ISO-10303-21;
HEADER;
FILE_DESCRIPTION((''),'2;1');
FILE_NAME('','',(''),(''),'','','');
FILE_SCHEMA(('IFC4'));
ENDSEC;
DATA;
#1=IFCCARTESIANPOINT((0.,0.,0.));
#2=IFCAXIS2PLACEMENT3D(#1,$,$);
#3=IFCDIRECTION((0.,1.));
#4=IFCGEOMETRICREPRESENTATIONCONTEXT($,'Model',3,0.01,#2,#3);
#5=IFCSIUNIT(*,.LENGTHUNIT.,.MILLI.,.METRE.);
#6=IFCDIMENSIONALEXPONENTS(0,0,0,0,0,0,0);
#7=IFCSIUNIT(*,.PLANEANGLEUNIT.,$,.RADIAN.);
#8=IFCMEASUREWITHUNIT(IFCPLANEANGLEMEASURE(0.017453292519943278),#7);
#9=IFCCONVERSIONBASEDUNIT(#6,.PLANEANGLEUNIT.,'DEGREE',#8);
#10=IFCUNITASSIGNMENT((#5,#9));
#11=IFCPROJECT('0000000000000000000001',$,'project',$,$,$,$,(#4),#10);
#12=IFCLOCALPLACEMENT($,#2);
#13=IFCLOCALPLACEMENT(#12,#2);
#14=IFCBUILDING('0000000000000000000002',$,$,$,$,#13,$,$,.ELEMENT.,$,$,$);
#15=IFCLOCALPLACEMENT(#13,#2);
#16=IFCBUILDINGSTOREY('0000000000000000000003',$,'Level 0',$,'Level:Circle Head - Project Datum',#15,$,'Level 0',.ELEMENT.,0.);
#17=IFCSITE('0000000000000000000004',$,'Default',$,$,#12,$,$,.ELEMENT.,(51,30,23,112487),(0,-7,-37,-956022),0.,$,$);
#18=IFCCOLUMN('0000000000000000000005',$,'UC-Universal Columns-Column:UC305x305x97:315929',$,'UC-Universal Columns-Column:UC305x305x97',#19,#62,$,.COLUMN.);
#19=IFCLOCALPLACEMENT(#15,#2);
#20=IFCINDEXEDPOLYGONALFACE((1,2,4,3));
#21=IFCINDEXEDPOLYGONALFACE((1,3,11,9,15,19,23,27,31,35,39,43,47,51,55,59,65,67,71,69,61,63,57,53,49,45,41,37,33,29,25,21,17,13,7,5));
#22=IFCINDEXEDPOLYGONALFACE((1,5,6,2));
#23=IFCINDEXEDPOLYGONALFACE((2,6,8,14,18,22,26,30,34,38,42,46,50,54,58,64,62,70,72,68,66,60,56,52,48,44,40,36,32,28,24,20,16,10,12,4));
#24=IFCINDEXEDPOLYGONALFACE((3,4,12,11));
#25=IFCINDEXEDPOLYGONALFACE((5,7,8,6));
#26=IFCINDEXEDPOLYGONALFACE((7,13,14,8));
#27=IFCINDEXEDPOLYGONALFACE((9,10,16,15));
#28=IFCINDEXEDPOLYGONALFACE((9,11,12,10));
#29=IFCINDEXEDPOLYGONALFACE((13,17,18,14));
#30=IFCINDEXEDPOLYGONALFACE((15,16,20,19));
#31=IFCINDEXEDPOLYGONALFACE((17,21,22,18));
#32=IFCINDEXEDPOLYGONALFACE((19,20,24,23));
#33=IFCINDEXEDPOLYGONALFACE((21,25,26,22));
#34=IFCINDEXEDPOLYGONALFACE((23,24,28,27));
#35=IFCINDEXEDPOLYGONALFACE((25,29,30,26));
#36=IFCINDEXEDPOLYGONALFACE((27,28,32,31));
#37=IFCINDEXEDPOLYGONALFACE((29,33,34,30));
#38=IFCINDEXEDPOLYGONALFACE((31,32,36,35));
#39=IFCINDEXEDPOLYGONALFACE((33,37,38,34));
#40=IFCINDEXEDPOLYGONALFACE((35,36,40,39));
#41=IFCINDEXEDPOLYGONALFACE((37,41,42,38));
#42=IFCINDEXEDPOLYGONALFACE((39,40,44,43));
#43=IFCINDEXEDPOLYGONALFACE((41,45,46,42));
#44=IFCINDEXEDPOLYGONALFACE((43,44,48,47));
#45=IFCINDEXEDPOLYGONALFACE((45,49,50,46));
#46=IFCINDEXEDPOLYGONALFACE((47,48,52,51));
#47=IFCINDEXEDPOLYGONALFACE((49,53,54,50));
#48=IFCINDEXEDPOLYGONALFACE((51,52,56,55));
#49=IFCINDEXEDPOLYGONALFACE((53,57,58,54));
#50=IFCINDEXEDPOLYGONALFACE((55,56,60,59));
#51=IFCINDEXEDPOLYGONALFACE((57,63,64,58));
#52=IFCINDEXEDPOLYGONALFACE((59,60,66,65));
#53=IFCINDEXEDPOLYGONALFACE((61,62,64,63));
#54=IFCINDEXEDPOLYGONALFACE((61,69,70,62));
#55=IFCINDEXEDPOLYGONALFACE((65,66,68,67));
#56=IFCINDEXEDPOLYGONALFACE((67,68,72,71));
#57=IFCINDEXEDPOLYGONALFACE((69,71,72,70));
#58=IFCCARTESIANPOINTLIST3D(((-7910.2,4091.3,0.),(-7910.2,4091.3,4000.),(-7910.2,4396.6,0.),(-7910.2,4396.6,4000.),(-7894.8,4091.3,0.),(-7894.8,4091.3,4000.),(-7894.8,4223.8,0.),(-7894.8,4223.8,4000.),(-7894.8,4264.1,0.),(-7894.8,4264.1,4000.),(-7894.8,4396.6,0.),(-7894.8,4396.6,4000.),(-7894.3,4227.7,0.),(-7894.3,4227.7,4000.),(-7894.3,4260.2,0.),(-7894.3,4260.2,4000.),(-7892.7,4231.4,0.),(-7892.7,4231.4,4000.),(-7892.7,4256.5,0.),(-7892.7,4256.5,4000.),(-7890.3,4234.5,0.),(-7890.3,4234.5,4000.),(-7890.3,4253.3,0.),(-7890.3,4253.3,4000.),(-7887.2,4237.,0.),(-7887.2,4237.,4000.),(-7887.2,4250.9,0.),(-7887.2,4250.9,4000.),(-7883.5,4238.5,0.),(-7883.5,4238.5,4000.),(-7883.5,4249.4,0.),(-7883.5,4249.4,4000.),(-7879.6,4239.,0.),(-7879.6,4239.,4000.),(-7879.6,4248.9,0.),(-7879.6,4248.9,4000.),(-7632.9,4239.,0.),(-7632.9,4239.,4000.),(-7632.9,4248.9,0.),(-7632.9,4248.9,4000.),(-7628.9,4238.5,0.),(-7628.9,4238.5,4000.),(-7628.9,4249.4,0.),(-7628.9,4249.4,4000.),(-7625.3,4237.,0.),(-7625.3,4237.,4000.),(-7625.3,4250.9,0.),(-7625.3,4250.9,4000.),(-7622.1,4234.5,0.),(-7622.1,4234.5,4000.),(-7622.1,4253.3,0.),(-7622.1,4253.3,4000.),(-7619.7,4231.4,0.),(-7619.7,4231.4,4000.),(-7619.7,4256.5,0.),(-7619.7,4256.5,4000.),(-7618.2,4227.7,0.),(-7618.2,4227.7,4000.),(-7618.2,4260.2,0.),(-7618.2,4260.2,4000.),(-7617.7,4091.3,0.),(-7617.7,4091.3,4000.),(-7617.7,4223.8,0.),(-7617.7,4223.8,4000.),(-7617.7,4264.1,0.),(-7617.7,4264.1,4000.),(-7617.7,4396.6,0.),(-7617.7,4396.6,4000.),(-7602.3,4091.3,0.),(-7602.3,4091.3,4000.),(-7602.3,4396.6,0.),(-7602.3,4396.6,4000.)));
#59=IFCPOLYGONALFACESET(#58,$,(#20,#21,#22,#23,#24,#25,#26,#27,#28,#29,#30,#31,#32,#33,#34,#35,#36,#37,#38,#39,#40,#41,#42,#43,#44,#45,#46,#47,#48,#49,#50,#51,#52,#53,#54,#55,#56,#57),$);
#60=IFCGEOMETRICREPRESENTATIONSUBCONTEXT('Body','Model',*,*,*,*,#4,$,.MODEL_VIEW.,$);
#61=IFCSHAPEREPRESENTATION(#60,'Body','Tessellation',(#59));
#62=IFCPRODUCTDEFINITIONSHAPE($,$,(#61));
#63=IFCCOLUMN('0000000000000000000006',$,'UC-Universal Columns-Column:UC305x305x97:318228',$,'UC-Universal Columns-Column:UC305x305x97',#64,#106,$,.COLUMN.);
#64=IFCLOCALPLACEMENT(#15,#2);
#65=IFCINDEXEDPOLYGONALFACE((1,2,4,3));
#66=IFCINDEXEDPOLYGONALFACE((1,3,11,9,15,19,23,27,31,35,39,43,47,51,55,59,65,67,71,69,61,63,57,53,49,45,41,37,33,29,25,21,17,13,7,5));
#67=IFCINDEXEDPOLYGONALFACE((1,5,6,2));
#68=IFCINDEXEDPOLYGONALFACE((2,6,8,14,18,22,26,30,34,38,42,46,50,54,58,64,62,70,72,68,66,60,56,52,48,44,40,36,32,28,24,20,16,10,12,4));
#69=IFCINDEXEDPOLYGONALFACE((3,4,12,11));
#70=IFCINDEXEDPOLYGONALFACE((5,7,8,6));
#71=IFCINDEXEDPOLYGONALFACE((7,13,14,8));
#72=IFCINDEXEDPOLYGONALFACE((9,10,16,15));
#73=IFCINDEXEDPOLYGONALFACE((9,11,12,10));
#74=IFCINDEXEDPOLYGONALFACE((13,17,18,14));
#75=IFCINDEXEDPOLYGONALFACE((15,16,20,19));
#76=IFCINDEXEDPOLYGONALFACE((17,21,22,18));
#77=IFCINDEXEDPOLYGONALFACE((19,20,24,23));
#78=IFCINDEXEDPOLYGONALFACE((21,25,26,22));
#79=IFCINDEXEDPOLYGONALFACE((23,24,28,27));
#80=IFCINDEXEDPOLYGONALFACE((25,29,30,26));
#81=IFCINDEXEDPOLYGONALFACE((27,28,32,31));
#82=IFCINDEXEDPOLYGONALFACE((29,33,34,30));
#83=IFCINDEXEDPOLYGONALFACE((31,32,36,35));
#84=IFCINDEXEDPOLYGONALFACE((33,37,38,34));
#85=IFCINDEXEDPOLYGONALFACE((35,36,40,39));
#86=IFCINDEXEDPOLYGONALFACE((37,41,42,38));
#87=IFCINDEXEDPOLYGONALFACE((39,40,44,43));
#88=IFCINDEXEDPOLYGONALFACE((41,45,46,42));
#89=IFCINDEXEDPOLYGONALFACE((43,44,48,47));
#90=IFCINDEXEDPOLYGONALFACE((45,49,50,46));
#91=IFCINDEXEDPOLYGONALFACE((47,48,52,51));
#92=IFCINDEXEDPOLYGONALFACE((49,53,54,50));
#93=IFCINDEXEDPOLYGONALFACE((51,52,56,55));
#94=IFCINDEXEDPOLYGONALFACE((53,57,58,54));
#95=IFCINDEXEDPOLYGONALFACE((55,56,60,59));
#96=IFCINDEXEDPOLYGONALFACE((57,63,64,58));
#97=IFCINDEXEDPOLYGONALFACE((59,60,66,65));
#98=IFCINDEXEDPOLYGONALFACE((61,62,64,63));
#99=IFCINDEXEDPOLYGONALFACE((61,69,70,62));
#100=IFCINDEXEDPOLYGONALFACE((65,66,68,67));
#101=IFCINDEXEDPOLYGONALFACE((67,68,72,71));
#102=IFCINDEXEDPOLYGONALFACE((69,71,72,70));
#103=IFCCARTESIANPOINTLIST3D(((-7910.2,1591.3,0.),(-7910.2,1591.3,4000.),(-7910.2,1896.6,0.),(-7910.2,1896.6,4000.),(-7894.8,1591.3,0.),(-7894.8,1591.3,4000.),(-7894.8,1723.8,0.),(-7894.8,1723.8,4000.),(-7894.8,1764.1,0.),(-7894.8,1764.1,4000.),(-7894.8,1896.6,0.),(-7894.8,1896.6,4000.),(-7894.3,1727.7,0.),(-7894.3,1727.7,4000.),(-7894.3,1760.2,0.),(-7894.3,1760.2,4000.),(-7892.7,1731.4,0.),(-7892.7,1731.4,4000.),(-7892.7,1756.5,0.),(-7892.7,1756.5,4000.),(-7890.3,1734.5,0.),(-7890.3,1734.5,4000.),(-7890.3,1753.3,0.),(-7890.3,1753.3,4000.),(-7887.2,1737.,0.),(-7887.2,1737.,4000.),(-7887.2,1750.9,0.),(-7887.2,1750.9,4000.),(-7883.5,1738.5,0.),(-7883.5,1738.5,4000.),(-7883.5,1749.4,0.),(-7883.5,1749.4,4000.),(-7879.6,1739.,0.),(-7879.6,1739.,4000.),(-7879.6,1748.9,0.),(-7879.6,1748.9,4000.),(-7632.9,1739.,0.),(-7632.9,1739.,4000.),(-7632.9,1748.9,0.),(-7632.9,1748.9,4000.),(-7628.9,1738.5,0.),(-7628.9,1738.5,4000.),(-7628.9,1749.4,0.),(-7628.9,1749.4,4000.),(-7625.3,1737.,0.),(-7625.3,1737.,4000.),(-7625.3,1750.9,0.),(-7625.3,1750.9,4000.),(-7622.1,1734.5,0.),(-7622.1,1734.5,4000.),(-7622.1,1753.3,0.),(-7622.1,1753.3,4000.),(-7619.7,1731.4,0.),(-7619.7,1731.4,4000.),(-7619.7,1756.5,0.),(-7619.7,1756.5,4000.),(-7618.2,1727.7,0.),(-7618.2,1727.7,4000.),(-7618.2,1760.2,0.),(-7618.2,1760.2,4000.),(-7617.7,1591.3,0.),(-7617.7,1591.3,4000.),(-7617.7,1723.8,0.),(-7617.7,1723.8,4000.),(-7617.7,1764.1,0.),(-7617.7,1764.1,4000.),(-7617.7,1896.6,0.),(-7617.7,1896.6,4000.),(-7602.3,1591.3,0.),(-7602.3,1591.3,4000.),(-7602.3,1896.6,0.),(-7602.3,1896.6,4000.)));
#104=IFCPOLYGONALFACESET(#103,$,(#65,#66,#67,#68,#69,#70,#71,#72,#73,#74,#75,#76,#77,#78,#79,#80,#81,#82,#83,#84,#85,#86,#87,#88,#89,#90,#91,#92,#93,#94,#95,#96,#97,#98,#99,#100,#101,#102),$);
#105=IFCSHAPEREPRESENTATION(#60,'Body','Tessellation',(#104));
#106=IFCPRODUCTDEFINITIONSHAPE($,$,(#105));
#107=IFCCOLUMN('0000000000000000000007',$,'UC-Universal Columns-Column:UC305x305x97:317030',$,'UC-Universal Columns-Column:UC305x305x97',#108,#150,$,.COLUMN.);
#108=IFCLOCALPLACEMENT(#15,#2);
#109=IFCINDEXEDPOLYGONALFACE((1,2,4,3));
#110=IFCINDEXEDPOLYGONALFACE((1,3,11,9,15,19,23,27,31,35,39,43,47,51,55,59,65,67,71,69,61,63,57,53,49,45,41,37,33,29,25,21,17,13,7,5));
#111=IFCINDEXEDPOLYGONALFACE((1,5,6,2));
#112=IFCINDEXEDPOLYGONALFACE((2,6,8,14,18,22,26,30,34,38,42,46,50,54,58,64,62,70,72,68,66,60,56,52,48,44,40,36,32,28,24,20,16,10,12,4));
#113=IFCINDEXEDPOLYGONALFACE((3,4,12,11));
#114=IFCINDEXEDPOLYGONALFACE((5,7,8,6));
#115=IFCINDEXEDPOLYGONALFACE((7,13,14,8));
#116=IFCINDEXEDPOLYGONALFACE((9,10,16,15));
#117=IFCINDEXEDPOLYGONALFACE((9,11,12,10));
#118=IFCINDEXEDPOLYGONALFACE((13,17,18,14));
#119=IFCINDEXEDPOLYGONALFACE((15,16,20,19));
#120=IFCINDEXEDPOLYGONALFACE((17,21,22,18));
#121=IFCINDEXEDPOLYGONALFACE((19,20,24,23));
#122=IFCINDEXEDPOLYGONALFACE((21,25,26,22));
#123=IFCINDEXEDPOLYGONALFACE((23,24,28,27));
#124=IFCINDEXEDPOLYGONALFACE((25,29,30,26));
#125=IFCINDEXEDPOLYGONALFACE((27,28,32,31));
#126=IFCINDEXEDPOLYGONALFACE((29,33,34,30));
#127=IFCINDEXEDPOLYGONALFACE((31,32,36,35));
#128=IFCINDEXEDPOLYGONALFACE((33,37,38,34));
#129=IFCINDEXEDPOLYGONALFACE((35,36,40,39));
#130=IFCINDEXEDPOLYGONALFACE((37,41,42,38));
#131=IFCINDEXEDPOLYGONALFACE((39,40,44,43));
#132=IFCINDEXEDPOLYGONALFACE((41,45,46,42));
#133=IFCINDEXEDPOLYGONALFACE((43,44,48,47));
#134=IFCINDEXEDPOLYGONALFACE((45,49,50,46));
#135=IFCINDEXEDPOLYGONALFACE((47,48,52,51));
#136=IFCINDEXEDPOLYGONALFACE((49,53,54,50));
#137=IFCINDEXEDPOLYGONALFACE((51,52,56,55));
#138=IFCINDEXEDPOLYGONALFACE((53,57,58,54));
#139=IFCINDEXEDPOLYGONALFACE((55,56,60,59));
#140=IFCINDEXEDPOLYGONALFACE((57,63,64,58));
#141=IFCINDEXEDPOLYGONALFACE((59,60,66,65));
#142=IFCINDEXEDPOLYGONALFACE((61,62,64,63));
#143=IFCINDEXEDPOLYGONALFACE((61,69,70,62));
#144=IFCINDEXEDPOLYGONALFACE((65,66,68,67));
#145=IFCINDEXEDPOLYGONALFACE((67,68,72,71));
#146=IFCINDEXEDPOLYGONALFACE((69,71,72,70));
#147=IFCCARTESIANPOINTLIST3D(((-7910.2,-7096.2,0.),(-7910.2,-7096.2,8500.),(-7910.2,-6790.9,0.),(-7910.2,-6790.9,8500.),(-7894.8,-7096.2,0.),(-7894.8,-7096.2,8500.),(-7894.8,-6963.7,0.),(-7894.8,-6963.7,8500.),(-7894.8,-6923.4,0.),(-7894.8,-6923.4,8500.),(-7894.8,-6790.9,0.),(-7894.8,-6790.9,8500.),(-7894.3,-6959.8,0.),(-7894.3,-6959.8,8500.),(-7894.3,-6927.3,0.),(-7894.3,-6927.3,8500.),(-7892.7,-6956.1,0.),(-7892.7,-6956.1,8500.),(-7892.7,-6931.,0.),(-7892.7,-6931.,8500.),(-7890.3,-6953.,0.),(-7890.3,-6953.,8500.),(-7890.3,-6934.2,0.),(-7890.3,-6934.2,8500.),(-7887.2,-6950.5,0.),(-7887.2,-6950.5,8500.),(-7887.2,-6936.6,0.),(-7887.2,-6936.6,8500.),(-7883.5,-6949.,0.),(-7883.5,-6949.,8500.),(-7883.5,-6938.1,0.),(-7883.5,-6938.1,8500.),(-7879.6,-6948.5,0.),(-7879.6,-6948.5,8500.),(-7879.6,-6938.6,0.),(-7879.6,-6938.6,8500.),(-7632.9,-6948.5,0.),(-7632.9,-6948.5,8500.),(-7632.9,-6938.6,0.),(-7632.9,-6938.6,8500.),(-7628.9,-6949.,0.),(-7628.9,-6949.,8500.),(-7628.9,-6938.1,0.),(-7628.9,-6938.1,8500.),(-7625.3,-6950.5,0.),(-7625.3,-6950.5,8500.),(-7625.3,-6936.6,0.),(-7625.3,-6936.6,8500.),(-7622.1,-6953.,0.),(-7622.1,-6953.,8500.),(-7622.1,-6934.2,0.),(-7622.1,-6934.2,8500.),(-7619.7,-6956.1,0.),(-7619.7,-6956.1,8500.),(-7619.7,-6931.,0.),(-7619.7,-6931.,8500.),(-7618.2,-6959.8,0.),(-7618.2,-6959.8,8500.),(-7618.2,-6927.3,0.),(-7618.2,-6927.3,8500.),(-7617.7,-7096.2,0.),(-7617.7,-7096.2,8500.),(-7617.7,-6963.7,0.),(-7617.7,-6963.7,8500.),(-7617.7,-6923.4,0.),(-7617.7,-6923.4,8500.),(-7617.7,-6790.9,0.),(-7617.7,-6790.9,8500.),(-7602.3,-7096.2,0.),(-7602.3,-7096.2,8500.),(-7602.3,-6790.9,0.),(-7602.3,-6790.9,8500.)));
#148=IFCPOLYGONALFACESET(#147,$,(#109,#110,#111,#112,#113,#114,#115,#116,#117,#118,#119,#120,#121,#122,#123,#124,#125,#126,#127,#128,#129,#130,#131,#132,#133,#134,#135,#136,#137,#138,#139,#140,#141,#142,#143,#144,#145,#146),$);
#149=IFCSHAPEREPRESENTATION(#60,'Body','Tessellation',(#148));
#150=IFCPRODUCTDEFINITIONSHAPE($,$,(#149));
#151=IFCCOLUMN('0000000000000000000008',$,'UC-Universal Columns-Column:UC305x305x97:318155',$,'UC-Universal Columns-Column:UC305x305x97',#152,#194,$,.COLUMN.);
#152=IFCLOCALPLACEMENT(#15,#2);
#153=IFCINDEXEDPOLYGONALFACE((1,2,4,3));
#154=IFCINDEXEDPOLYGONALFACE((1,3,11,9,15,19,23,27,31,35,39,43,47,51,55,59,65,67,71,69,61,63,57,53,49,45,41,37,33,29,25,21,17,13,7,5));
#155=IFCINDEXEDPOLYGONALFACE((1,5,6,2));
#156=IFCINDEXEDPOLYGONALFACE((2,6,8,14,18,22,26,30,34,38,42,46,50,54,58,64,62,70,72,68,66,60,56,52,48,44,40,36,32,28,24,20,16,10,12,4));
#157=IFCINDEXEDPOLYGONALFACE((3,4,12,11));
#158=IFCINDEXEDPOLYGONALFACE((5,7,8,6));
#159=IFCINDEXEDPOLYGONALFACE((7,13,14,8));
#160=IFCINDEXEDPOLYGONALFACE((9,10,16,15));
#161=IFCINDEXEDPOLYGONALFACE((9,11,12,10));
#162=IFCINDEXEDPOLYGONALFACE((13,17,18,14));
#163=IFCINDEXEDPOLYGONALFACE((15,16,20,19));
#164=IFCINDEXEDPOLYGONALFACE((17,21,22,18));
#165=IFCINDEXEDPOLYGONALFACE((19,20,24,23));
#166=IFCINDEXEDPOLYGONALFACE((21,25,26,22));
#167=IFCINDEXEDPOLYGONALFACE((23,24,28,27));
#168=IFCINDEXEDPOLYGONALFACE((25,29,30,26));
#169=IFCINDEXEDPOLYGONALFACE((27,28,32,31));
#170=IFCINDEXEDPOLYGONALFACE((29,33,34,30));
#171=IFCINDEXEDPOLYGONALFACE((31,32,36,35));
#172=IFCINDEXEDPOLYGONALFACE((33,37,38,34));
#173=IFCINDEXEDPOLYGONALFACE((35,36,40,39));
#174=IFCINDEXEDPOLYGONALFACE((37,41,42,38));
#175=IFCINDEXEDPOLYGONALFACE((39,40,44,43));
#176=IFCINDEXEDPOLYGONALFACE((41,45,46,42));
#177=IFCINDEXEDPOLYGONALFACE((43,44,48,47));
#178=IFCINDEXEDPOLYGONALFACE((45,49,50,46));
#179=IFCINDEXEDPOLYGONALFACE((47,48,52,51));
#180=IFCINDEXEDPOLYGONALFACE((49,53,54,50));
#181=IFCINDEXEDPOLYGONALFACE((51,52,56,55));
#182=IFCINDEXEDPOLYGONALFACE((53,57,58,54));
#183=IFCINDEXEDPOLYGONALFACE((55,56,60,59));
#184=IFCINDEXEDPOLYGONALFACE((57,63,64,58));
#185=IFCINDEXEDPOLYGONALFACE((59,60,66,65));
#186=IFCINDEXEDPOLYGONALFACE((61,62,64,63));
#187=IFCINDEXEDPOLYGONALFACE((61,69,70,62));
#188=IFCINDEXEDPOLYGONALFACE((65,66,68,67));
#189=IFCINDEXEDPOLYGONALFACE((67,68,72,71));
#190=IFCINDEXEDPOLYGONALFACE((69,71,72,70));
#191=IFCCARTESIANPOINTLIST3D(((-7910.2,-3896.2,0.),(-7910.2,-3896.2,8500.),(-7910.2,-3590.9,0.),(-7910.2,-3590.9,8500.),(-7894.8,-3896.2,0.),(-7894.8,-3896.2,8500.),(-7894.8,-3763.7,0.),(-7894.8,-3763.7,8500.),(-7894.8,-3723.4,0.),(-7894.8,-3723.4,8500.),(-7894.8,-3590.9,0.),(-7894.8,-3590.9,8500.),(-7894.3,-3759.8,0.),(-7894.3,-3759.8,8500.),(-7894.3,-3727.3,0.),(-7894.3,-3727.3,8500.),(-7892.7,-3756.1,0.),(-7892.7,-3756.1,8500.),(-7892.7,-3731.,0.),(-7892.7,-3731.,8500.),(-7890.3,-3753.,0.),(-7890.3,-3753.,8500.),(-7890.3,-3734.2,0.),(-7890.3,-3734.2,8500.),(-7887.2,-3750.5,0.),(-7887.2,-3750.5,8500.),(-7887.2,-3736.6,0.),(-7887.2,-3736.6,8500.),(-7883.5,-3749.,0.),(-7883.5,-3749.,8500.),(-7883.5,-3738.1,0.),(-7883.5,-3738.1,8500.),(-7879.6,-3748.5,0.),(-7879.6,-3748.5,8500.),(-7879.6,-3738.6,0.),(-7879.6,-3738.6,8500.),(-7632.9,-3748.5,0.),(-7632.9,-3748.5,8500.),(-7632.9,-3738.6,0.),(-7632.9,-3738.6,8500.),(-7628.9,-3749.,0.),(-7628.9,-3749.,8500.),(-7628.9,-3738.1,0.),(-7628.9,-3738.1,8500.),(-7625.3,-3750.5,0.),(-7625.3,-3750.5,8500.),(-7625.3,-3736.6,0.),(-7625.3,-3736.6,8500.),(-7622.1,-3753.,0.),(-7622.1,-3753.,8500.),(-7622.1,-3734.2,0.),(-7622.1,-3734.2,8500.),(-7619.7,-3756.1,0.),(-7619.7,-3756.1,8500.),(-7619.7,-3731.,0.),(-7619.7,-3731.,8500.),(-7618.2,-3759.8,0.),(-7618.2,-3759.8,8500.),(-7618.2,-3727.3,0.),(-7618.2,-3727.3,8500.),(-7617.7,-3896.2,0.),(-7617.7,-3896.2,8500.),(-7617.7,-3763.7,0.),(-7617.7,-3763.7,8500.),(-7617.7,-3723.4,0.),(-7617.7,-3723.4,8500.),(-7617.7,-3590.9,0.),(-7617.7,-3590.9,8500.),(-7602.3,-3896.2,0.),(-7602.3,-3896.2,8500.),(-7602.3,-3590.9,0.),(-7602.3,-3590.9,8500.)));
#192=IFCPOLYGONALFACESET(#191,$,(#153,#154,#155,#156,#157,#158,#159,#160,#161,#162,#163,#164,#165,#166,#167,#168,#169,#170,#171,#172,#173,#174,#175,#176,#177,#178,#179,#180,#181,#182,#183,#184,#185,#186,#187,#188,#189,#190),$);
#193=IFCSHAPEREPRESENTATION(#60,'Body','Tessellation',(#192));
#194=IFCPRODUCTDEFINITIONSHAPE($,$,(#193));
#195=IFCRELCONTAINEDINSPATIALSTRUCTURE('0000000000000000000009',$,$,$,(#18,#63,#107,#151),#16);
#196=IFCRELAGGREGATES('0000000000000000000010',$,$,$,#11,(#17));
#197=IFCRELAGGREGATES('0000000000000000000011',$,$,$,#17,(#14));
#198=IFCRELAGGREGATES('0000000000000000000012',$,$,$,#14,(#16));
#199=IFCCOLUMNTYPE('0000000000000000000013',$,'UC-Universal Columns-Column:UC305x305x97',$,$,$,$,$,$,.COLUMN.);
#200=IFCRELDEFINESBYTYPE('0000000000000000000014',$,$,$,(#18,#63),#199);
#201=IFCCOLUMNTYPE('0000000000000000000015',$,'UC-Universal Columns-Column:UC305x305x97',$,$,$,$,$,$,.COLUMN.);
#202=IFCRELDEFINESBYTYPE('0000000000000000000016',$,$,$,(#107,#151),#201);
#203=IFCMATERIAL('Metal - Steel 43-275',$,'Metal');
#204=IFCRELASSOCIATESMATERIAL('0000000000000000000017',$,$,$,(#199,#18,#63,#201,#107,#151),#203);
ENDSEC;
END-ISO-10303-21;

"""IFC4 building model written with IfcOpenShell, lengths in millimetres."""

from ifc_helpers import new_model, entity, si_unit, converted_unit, direction, frame, origin, place, context, subcontext, project, spatial, line, arc, indexed_curve, outline, extrude, source, transform, mapped, material, type_object, type_shapes, element, save


model = new_model("IFC4")

# Units and contexts
model_context = context("Model", 3, precision=0.01, world=origin(), true_north=direction((0.0, 1.0)))
body_context = subcontext(model_context, "Body", "Model", "MODEL_VIEW")
ifc_project = project(units=[si_unit("LENGTHUNIT", "METRE", prefix="MILLI"), converted_unit("PLANEANGLEUNIT", "DEGREE", entity("IfcPlaneAngleMeasure", 0.017453292519943278), si_unit("PLANEANGLEUNIT", "RADIAN"), dimensions=[0, 0, 0, 0, 0, 0, 0])], contexts=[model_context])

# Site, building, storey
site_placement = place(None, origin())
site = spatial("IfcSite", under=ifc_project, at=site_placement, Name="Default", CompositionType="ELEMENT", RefLatitude=(51, 30, 23, 112487), RefLongitude=(0, -7, -37, -956022), RefElevation=0.0)
building_placement = place(site_placement, origin())
building = spatial("IfcBuilding", under=site, at=building_placement, CompositionType="ELEMENT")
storey_placement = place(building_placement, origin())
storey = spatial("IfcBuildingStorey", under=building, at=storey_placement, Name="Level 0", ObjectType="Level:Circle Head - Project Datum", LongName="Level 0", CompositionType="ELEMENT", Elevation=0.0)

# Columns
ifc_material_1 = material(Name="Metal - Steel 43-275", Category="Metal")
column_type_1 = type_object("IfcColumnType", Name="UC-Universal Columns-Column:UC305x305x97", PredefinedType="COLUMN", material=ifc_material_1)
shared_shape_1 = source(origin(), body_context, "Body", "SweptSolid", [
    extrude(outline(indexed_curve([(-152.6, -153.9), (152.6, -153.9), (152.6, -138.5), (20.2, -138.5), (9.4, -134.1), (4.9, -123.4), (4.9, 123.3), (9.4, 134.1), (20.1, 138.5), (152.6, 138.5), (152.6, 153.9), (-152.6, 153.9), (-152.6, 138.5), (-20.2, 138.6), (-9.4, 134.1), (-5.0, 123.4), (-5.0, -123.3), (-9.4, -134.1), (-20.2, -138.5), (-152.6, -138.5)], segments=[line(1, 2, 3, 4), arc(4, 5, 6), line(6, 7), arc(7, 8, 9), line(9, 10, 11, 12, 13, 14), arc(14, 15, 16), line(16, 17), arc(17, 18, 19), line(19, 20, 1)], self_intersect=False)), frame((0.0, 0.0, 0.0), z_axis=(0.0, 0.0, 1.0), x_axis=(-1.0, 0.0, 0.0)), (0.0, 0.0, 1.0), 4000.0),
])
type_shapes(column_type_1, [shared_shape_1])
for number, where, z_axis, x_axis, name in (
    (1, (-7756.2, 4243.9, 0.0), (0.0, 0.0, 1.0), (0.0, 1.0, 0.0), "UC-Universal Columns-Column:UC305x305x97:315929"),
    (2, (-7756.2, 1743.9, 0.0), (0.0, 0.0, 1.0), (0.0, 1.0, 0.0), "UC-Universal Columns-Column:UC305x305x97:318228"),
):
    element("IfcColumn", number, at=place(storey_placement, frame(where, z_axis=z_axis, x_axis=x_axis)), inside=storey, type_object=column_type_1, material=ifc_material_1, Name=name, ObjectType="UC-Universal Columns-Column:UC305x305x97", PredefinedType="COLUMN", context=body_context, shape_type="MappedRepresentation", body=[
        mapped(shared_shape_1, transform((0.0, 0.0, 0.0), scale=1.0)),
    ])
column_type_2 = type_object("IfcColumnType", Name="UC-Universal Columns-Column:UC305x305x97", PredefinedType="COLUMN", material=ifc_material_1)
shared_shape_2 = source(origin(), body_context, "Body", "SweptSolid", [
    extrude(outline(indexed_curve([(-152.6, -153.9), (152.6, -153.9), (152.6, -138.5), (20.2, -138.5), (9.4, -134.1), (4.9, -123.4), (4.9, 123.3), (9.4, 134.1), (20.1, 138.5), (152.6, 138.5), (152.6, 153.9), (-152.6, 153.9), (-152.6, 138.5), (-20.2, 138.6), (-9.4, 134.1), (-5.0, 123.4), (-5.0, -123.3), (-9.4, -134.1), (-20.2, -138.5), (-152.6, -138.5)], segments=[line(1, 2, 3, 4), arc(4, 5, 6), line(6, 7), arc(7, 8, 9), line(9, 10, 11, 12, 13, 14), arc(14, 15, 16), line(16, 17), arc(17, 18, 19), line(19, 20, 1)], self_intersect=False)), frame((0.0, 0.0, 0.0), z_axis=(0.0, 0.0, 1.0), x_axis=(-1.0, 0.0, 0.0)), (0.0, 0.0, 1.0), 8500.0),
])
type_shapes(column_type_2, [shared_shape_2])
for number, where, z_axis, x_axis, name in (
    (3, (-7756.2, -6943.6, 0.0), (0.0, 0.0, 1.0), (0.0, -1.0, 0.0), "UC-Universal Columns-Column:UC305x305x97:317030"),
    (4, (-7756.2, -3743.6, 0.0), (0.0, 0.0, 1.0), (0.0, -1.0, 0.0), "UC-Universal Columns-Column:UC305x305x97:318155"),
):
    element("IfcColumn", number, at=place(storey_placement, frame(where, z_axis=z_axis, x_axis=x_axis)), inside=storey, type_object=column_type_2, material=ifc_material_1, Name=name, ObjectType="UC-Universal Columns-Column:UC305x305x97", PredefinedType="COLUMN", context=body_context, shape_type="MappedRepresentation", body=[
        mapped(shared_shape_2, transform((0.0, 0.0, 0.0), scale=1.0)),
    ])

save(model, "model.ifc")
